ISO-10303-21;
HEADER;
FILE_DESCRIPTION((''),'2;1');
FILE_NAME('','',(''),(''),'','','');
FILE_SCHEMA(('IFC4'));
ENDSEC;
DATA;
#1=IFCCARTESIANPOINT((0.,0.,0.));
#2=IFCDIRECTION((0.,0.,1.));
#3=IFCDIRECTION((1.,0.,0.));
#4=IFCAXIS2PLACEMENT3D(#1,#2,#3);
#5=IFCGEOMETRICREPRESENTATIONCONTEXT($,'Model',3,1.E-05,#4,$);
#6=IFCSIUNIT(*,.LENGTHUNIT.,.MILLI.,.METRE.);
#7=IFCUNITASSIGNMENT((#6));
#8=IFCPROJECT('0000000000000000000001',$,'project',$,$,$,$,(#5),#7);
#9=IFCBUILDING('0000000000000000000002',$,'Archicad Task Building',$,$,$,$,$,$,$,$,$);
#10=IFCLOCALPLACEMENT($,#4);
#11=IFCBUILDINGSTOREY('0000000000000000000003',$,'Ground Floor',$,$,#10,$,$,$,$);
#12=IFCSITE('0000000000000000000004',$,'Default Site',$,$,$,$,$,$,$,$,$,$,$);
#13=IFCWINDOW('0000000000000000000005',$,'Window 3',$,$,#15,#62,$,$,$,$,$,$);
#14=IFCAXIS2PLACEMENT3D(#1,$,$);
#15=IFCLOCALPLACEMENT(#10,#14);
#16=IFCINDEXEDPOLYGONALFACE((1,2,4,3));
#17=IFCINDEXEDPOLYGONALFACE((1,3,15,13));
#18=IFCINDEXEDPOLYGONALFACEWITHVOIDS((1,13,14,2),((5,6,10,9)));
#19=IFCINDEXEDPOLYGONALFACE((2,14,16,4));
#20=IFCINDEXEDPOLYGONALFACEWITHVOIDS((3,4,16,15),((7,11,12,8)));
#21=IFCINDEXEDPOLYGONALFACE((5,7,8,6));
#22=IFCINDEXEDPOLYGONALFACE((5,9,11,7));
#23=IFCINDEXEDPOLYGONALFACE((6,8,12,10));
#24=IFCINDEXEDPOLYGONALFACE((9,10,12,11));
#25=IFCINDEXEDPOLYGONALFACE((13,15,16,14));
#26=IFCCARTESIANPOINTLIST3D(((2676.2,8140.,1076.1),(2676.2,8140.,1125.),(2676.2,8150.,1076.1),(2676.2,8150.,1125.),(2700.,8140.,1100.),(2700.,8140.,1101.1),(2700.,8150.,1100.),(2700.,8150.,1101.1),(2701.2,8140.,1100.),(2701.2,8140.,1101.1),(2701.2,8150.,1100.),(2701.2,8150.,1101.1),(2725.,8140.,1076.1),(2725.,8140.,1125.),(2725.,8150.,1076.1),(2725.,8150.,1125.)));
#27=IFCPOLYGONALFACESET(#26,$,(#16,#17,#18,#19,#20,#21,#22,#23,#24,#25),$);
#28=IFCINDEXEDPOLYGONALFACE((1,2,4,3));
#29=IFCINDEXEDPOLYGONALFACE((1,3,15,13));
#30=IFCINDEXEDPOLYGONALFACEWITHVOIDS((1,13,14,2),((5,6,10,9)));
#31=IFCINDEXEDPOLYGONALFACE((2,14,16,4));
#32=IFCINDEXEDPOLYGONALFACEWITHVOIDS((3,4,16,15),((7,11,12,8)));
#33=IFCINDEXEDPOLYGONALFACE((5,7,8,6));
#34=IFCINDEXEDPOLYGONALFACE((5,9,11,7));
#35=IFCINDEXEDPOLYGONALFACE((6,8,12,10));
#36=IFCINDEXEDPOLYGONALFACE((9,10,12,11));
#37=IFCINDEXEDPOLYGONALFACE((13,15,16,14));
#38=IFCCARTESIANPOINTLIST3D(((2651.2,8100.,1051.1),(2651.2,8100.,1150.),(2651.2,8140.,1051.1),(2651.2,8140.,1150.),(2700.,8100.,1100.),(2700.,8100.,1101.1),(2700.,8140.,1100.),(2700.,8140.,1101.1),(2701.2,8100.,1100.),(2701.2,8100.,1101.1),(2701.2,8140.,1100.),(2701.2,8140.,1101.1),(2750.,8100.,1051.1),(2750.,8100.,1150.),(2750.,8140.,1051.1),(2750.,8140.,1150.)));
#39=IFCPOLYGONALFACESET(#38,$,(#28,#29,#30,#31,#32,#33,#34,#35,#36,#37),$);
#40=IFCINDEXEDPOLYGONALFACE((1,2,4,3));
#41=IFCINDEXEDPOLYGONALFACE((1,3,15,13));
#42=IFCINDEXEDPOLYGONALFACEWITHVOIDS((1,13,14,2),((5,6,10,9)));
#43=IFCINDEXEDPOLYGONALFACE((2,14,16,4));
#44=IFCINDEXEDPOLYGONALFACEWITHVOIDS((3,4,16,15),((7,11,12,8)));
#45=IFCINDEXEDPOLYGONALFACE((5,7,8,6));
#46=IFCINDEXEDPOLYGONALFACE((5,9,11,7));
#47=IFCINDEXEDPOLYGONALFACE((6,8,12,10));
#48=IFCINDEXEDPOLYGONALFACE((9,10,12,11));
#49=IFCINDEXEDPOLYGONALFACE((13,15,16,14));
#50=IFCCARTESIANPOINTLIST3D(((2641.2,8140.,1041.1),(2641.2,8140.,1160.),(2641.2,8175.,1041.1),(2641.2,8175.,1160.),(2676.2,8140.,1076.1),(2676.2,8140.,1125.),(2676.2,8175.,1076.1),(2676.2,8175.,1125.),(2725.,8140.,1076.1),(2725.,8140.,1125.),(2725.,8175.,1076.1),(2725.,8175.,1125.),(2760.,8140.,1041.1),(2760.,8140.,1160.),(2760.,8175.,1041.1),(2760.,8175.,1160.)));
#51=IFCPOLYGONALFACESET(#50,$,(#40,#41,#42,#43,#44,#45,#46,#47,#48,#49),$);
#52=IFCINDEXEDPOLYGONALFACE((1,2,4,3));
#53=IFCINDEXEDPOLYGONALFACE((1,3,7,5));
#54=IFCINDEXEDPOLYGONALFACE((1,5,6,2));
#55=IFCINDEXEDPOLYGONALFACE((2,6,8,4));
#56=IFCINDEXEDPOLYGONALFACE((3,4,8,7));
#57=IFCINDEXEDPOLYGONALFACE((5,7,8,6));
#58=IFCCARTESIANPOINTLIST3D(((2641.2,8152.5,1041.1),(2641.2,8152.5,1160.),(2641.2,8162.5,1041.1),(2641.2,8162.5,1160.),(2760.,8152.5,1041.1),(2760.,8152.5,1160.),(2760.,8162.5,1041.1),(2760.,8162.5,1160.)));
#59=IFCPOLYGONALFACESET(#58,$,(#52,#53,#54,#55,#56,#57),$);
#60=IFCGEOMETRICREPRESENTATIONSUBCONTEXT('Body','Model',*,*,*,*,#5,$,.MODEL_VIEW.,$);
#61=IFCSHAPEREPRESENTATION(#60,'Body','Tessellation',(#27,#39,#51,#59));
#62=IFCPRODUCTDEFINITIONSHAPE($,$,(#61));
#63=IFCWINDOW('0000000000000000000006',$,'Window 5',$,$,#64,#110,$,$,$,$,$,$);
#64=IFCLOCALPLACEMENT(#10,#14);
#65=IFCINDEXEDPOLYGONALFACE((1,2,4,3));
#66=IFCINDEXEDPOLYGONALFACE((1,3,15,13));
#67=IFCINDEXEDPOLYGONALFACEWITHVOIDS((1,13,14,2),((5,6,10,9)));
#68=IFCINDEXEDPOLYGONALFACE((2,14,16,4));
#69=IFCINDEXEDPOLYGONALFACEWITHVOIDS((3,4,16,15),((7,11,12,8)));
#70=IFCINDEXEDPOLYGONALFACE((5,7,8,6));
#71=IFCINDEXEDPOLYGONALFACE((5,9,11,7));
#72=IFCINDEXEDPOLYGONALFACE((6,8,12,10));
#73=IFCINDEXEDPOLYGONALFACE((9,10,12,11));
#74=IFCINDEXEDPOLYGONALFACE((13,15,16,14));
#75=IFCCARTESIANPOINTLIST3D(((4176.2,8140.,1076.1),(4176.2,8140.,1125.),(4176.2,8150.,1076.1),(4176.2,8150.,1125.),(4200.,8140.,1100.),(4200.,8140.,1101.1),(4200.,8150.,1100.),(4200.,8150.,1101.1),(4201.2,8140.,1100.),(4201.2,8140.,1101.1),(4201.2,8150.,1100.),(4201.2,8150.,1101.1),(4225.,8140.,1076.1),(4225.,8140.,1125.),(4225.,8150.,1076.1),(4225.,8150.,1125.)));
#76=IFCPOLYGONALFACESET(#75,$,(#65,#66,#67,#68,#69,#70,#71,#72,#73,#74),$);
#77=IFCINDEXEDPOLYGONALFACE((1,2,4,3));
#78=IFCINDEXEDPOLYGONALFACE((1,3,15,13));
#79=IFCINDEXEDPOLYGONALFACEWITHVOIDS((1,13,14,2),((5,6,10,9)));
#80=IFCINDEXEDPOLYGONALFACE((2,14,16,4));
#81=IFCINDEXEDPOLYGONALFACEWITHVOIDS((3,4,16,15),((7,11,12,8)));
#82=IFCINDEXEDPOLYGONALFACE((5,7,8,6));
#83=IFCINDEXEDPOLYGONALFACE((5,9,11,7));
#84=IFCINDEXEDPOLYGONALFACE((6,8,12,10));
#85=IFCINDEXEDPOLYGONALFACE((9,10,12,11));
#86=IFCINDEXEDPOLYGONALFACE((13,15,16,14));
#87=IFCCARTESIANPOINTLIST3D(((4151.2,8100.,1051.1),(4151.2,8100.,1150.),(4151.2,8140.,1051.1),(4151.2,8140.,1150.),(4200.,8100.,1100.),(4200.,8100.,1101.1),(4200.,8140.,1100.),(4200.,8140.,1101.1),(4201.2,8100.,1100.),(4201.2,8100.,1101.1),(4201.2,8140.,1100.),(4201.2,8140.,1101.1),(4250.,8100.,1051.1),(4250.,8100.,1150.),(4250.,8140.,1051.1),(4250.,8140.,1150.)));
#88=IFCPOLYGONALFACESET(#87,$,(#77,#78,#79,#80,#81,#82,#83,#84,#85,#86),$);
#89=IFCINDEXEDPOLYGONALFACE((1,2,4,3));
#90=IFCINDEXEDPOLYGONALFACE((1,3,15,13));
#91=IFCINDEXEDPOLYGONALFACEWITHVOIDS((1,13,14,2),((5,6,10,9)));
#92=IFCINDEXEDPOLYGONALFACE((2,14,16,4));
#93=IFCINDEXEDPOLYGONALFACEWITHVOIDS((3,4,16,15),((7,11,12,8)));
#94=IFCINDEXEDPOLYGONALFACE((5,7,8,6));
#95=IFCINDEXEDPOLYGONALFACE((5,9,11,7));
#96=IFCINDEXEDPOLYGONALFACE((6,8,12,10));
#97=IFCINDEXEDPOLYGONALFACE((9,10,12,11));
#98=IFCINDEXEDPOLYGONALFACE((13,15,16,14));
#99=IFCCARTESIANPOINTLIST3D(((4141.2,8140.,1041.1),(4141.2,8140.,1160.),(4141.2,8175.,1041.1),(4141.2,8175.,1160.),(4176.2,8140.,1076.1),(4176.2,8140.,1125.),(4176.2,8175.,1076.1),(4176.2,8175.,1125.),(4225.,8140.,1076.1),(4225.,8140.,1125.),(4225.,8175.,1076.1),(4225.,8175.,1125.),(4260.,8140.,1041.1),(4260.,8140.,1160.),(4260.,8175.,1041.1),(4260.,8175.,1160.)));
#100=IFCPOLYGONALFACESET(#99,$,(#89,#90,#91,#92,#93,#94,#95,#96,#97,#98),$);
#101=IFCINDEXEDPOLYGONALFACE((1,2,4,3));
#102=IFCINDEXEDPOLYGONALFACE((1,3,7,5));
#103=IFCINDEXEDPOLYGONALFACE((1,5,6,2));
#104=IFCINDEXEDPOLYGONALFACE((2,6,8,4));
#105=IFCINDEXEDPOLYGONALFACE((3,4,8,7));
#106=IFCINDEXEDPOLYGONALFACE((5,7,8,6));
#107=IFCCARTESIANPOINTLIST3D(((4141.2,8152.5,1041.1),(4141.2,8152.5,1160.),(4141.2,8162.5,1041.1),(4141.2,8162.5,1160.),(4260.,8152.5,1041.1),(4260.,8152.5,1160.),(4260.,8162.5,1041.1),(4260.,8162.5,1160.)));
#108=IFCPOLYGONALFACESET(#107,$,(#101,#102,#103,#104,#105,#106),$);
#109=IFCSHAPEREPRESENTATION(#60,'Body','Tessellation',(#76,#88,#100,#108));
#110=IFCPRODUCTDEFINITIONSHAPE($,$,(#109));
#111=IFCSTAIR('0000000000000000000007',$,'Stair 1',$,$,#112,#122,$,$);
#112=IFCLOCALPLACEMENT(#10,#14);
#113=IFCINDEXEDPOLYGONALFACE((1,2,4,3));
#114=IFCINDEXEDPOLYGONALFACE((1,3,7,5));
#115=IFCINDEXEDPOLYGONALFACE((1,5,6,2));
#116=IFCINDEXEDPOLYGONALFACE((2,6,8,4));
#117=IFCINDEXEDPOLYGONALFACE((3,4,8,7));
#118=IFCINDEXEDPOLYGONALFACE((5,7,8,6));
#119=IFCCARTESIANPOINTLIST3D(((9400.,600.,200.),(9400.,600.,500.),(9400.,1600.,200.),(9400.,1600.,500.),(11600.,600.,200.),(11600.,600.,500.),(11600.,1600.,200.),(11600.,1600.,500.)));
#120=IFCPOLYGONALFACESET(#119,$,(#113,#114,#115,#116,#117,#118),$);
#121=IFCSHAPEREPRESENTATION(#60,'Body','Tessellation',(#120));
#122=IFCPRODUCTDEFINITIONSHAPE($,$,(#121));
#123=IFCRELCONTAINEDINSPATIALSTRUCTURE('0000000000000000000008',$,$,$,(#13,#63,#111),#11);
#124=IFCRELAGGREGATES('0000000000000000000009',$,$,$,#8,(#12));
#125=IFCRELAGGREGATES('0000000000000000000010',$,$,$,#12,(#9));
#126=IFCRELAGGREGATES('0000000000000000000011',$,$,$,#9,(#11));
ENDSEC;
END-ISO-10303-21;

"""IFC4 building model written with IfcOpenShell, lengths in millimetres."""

from ifc_helpers import new_model, si_unit, frame, origin_with_axes, place, context, subcontext, project, spatial, line, indexed_curve, outline, extrude, element, save


model = new_model("IFC4")

# Units and contexts
model_context = context("Model", 3, precision=1e-05, world=origin_with_axes())
body_context = subcontext(model_context, "Body", "Model", "MODEL_VIEW")
ifc_project = project(units=[si_unit("LENGTHUNIT", "METRE", prefix="MILLI")], contexts=[model_context])

# Site, building, storey
site = spatial("IfcSite", under=ifc_project, Name="Default Site")
building = spatial("IfcBuilding", under=site, Name="Archicad Task Building")
storey_placement = place(None, origin_with_axes())
storey = spatial("IfcBuildingStorey", under=building, at=storey_placement, Name="Ground Floor")

# Windows
for number, where, z_axis, x_axis, name in (
    (1, (2700.0, 8050.0, 1100.0), (0.0, 0.0, 1.0), (1.0, 0.0, 0.0), "Window 3"),
    (2, (4200.0, 8050.0, 1100.0), (0.0, 0.0, 1.0), (1.0, 0.0, 0.0), "Window 5"),
):
    element("IfcWindow", number, at=place(storey_placement, frame(where, z_axis=z_axis, x_axis=x_axis)), inside=storey, Name=name, context=body_context, shape_type="SweptSolid", body=[
        extrude(outline(indexed_curve([(0.0, 0.0), (1.2, 0.0), (1.2, 1.1), (0.0, 1.1)], segments=[line(1, 2, 3, 4, 1)]), holes=[indexed_curve([(25.0, 25.0), (-23.8, 25.0), (-23.8, -23.9), (25.0, -23.9)], segments=[line(1, 2, 3, 4, 1)])]), frame((0.0, 90.0, 0.0), z_axis=(0.0, -1.0, 0.0), x_axis=(1.0, 0.0, 0.0)), (0.0, 0.0, -1.0), 10.0),
        extrude(outline(indexed_curve([(0.0, 0.0), (1.2, 0.0), (1.2, 1.1), (0.0, 1.1)], segments=[line(1, 2, 3, 4, 1)]), holes=[indexed_curve([(50.0, 50.0), (-48.8, 50.0), (-48.8, -48.9), (50.0, -48.9)], segments=[line(1, 2, 3, 4, 1)])]), frame((0.0, 50.0, 0.0), z_axis=(0.0, -1.0, 0.0), x_axis=(1.0, 0.0, 0.0)), (0.0, 0.0, -1.0), 40.0),
        extrude(outline(indexed_curve([(0.0, 0.0), (-48.8, 0.0), (-48.8, -48.9), (0.0, -48.9)], segments=[line(1, 2, 3, 4, 1)]), holes=[indexed_curve([(35.0, 35.0), (-83.8, 35.0), (-83.8, -83.9), (35.0, -83.9)], segments=[line(1, 2, 3, 4, 1)])]), frame((25.0, 90.0, 25.0), z_axis=(0.0, -1.0, 0.0), x_axis=(1.0, 0.0, 0.0)), (0.0, 0.0, -1.0), 35.0),
        extrude(outline(indexed_curve([(35.0, 35.0), (-83.8, 35.0), (-83.8, -83.9), (35.0, -83.9)], segments=[line(1, 2, 3, 4, 1)])), frame((25.0, 102.5, 25.0), z_axis=(0.0, -1.0, 0.0), x_axis=(1.0, 0.0, 0.0)), (0.0, 0.0, -1.0), 10.0),
    ])

# Stair
stair_placement = place(storey_placement, frame((9400.0, 600.0, 200.0), z_axis=(0.0, 0.0, 1.0), x_axis=(1.0, 0.0, 0.0)))
element("IfcStair", 3, at=stair_placement, inside=storey, Name="Stair 1", context=body_context, shape_type="SweptSolid", body=[
    extrude(outline(indexed_curve([(0.0, 0.0), (2200.0, 0.0), (2200.0, 1000.0), (0.0, 1000.0), (0.0, 0.0)])), None, (0.0, 0.0, 1.0), 300.0),
])

save(model, "model.ifc")
